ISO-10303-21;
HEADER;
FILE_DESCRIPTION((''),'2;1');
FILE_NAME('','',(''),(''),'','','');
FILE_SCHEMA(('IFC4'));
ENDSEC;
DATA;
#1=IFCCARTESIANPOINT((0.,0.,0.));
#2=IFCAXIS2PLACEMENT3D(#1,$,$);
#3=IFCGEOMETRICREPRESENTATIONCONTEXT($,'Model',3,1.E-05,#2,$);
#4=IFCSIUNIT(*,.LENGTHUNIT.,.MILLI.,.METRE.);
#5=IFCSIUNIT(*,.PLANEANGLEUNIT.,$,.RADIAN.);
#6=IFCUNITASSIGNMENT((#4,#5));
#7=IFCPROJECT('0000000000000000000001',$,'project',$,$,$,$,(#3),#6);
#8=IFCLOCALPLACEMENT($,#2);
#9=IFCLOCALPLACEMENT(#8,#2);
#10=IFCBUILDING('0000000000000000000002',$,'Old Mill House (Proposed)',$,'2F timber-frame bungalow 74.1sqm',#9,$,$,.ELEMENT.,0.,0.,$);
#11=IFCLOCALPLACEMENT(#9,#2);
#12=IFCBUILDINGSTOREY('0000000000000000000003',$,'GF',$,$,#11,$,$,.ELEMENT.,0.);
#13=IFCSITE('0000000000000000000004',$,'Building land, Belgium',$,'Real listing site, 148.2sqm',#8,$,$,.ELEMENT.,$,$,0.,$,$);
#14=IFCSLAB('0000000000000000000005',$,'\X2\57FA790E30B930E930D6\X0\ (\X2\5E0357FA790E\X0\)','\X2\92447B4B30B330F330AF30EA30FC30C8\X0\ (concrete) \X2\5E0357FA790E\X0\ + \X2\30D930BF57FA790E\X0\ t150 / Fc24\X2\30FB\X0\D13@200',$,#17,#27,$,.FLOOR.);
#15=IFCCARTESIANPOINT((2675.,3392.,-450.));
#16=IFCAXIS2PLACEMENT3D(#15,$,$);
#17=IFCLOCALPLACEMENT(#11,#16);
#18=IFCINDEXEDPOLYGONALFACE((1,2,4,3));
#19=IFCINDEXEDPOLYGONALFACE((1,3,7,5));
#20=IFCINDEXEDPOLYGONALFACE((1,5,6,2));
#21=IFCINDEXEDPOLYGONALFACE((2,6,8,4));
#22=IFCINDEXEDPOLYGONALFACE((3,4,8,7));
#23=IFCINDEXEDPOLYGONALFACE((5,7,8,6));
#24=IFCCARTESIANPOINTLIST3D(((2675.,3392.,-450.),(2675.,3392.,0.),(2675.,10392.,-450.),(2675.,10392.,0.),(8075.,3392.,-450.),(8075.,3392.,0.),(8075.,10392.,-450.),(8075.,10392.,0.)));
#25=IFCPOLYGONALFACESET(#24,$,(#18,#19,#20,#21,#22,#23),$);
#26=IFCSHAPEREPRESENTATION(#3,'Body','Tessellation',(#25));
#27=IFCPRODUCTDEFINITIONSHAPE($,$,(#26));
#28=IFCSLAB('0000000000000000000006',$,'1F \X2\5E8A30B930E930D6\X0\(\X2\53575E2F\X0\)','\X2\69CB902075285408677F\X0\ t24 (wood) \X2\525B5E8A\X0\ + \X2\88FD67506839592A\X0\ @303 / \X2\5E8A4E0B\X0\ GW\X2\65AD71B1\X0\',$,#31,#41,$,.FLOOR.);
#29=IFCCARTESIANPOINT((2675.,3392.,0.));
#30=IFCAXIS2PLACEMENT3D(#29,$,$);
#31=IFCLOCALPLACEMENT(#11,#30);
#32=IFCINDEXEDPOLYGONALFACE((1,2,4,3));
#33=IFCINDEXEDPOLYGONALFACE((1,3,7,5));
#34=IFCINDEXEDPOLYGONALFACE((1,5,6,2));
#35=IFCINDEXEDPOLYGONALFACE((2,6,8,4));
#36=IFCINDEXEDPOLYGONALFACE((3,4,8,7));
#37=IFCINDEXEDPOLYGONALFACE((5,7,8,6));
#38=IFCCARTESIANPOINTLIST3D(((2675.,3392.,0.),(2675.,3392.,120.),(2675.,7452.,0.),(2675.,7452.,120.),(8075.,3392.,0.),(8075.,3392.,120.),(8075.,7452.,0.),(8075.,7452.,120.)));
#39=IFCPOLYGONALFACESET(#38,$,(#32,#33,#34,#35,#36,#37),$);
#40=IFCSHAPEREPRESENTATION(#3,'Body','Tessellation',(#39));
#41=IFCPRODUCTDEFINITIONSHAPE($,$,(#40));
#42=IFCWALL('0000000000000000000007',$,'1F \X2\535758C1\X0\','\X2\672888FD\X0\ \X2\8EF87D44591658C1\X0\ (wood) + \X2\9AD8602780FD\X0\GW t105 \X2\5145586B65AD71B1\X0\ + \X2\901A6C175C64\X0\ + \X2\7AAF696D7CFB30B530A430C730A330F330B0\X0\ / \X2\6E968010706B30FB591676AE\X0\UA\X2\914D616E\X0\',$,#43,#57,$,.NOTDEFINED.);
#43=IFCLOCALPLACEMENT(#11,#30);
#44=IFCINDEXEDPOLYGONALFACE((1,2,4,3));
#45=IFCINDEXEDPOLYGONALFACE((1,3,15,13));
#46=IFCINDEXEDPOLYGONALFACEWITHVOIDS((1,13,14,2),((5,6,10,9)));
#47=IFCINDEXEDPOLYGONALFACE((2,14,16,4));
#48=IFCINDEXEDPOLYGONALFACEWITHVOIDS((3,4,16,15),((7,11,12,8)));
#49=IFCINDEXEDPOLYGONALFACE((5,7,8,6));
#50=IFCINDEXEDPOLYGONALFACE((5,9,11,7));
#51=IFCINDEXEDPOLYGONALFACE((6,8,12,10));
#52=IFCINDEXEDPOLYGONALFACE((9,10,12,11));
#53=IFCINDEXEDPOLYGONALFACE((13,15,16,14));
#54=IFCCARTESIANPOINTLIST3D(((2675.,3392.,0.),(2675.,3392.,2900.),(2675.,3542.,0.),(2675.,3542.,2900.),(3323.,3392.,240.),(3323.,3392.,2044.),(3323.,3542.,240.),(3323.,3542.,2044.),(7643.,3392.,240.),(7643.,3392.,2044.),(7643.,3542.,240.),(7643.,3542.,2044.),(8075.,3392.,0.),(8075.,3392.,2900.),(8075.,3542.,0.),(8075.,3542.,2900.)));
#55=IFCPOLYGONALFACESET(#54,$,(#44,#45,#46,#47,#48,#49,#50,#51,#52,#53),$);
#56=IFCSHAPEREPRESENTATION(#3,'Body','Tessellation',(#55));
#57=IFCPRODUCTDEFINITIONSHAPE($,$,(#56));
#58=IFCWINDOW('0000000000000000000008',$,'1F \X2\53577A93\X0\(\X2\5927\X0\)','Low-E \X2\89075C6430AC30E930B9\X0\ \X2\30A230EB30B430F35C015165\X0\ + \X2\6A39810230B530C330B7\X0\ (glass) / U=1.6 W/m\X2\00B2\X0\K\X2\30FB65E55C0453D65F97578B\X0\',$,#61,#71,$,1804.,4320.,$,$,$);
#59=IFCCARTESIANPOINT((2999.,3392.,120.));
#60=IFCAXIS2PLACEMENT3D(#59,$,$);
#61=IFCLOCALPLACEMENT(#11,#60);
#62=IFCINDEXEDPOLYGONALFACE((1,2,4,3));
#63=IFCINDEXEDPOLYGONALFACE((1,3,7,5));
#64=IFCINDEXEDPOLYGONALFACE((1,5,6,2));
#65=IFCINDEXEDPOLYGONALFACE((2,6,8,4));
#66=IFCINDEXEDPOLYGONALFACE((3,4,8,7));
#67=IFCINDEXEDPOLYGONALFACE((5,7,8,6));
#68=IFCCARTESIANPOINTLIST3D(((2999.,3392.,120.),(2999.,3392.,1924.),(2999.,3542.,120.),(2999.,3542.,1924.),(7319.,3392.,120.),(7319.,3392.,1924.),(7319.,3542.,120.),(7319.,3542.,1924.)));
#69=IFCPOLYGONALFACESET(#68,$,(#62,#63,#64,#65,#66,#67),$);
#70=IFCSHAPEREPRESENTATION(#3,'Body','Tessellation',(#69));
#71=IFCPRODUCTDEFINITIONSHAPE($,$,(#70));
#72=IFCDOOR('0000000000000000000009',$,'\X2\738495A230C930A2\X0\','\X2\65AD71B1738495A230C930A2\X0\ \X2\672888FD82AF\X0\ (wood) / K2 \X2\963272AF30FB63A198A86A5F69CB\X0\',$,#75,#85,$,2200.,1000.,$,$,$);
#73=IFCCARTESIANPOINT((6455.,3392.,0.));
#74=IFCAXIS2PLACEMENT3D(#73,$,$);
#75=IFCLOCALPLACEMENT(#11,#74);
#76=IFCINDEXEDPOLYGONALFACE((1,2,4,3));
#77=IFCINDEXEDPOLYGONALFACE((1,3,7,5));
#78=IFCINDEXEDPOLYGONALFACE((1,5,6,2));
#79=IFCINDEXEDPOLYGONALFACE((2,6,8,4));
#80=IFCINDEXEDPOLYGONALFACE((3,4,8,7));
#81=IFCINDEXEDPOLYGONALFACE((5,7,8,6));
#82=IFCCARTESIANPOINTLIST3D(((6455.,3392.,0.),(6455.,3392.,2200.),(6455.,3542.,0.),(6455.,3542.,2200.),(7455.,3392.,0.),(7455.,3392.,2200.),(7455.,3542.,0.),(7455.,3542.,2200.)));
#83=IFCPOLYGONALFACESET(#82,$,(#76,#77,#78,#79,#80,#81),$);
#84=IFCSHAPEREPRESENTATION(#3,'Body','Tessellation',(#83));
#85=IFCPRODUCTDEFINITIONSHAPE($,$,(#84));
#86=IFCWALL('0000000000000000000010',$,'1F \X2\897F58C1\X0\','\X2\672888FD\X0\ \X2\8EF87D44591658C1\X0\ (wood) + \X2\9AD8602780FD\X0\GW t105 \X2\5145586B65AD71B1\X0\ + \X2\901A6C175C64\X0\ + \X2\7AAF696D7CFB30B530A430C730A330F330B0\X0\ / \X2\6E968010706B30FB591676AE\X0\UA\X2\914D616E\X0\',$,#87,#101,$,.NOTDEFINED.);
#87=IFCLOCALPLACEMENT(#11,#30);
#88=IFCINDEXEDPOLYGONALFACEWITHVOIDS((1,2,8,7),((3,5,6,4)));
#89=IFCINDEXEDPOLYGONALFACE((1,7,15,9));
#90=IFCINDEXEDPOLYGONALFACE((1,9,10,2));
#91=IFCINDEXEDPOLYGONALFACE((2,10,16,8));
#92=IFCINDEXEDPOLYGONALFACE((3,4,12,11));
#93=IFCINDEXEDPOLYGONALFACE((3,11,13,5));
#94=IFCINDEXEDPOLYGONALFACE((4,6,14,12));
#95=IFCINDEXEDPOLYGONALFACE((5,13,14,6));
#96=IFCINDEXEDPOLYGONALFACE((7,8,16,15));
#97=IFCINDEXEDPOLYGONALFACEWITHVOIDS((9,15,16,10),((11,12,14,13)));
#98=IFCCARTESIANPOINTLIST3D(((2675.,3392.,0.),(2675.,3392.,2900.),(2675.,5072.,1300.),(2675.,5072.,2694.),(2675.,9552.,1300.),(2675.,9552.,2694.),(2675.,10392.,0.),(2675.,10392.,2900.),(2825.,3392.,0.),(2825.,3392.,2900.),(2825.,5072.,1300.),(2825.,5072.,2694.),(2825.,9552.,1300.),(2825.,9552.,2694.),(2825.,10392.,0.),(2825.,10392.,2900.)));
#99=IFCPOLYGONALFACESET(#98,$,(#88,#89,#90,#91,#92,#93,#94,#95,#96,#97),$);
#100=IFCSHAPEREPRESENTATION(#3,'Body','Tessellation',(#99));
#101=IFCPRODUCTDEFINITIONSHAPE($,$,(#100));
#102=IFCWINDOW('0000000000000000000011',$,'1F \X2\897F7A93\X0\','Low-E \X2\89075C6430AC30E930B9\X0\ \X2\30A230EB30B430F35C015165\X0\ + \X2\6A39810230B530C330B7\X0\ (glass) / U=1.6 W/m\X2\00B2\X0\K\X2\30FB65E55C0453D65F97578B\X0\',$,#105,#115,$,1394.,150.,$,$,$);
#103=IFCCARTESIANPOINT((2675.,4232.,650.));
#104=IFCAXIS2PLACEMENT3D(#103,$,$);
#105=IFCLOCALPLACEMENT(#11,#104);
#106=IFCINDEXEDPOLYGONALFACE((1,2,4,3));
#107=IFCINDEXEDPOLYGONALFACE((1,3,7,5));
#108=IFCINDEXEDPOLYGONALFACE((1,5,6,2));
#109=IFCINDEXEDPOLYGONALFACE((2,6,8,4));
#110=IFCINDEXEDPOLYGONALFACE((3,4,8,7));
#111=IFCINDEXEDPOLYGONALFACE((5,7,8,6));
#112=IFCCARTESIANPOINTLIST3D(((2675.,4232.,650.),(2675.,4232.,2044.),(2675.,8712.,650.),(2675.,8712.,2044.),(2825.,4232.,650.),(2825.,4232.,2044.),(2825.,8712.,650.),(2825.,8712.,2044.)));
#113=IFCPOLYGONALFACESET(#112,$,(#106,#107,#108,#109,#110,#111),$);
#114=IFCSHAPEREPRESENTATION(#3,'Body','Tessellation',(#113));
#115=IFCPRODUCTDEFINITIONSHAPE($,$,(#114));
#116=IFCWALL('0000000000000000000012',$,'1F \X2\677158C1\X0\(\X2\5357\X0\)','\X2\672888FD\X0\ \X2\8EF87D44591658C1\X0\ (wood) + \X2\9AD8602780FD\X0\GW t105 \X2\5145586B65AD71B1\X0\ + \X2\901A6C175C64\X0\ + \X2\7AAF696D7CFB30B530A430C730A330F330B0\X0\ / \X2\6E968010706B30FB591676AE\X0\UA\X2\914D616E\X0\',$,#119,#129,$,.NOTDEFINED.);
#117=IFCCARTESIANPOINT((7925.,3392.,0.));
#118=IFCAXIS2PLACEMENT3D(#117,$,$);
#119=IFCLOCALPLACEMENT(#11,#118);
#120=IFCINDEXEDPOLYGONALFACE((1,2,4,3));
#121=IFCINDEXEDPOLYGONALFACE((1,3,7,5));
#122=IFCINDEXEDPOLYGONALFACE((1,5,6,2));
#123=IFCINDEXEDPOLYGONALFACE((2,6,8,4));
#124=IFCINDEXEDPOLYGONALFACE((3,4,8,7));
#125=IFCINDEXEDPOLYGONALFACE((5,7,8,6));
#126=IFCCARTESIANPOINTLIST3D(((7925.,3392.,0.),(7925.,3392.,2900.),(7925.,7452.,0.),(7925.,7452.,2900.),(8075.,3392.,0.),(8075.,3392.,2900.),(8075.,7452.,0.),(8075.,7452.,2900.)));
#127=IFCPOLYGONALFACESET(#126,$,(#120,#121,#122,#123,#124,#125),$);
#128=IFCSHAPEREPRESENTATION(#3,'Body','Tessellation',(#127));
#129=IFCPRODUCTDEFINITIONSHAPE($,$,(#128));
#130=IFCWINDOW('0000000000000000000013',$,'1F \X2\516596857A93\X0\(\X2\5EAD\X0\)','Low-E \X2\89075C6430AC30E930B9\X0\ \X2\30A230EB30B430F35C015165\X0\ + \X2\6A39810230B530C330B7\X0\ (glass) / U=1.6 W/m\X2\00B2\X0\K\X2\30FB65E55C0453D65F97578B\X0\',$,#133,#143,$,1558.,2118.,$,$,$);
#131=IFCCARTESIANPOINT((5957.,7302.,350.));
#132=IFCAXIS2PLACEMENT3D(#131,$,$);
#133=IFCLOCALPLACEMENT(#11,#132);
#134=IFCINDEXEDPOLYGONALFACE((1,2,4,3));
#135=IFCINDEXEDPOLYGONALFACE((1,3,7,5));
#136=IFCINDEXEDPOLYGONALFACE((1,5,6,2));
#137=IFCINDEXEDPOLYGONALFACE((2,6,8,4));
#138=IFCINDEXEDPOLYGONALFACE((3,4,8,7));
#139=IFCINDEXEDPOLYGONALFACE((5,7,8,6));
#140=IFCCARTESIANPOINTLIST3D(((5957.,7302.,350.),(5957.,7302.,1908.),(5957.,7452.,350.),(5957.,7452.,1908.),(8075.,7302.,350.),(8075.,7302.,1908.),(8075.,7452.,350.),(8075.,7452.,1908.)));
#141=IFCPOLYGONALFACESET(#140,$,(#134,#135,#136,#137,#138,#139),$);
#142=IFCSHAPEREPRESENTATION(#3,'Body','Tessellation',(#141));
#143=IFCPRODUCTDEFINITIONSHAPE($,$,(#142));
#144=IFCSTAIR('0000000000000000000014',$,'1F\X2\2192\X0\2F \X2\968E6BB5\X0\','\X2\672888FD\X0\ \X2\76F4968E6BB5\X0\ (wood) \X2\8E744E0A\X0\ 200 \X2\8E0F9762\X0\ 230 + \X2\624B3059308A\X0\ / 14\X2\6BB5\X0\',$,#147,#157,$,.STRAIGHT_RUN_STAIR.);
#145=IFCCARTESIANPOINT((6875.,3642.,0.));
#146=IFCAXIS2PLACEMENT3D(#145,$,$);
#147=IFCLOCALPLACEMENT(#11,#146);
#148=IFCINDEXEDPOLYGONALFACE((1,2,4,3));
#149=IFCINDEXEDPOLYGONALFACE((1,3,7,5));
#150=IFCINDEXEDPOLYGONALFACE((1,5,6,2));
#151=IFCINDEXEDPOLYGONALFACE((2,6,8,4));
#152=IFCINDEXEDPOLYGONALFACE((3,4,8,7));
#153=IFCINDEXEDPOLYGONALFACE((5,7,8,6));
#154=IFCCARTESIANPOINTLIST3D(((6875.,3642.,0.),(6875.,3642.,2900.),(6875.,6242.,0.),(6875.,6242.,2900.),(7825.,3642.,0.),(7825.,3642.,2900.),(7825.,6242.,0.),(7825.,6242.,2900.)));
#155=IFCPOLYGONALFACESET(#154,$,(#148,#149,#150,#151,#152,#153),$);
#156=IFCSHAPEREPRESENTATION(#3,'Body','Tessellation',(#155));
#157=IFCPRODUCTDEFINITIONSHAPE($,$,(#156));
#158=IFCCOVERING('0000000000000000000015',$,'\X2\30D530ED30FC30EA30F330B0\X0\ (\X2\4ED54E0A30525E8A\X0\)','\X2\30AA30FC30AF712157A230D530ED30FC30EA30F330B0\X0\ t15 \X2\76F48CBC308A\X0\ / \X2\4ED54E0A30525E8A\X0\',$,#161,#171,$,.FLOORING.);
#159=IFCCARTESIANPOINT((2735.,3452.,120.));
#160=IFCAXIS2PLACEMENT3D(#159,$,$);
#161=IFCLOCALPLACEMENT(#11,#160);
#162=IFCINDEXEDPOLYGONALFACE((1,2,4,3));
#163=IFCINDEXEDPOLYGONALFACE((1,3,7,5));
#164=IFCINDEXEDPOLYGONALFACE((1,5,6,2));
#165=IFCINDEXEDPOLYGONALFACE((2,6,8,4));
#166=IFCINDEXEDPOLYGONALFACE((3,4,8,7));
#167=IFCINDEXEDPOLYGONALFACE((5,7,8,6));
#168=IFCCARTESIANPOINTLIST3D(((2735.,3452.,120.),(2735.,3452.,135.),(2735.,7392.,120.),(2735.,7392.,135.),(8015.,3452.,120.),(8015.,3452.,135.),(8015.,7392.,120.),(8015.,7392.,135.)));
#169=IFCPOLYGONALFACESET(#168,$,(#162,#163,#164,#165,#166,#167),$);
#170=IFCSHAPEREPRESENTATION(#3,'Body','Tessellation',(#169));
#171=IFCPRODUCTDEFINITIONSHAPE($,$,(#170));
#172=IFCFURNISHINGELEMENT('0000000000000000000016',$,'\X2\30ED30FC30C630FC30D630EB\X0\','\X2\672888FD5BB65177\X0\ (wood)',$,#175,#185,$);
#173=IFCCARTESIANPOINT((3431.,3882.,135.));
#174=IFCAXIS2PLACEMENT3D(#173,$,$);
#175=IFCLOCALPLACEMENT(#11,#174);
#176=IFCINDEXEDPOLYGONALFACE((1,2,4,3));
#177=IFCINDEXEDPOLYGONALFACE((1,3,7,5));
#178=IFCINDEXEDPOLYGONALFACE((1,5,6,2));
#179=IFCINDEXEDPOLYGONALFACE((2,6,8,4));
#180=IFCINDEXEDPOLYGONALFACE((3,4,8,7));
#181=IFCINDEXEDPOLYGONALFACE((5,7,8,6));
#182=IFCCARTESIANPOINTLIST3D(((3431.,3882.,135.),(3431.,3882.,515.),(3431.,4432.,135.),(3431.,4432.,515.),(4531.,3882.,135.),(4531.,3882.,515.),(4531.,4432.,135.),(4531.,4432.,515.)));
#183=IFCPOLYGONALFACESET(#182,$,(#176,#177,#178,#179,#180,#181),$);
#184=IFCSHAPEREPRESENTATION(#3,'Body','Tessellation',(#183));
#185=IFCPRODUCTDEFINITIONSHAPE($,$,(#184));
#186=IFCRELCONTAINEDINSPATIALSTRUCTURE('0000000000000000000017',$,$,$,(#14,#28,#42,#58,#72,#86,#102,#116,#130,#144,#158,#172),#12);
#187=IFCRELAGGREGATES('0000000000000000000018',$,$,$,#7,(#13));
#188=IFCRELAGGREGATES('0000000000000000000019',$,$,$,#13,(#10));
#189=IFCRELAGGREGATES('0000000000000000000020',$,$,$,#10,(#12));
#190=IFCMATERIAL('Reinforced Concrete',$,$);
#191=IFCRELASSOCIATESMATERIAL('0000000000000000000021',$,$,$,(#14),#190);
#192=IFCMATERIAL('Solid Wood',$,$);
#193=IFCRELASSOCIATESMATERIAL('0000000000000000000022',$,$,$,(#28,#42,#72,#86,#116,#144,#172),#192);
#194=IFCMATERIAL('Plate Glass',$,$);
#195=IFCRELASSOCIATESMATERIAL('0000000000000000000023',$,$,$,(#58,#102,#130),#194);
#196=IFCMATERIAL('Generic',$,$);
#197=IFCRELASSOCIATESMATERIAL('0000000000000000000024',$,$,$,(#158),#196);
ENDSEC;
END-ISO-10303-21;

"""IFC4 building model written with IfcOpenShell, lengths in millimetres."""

from ifc_helpers import new_model, si_unit, frame, frame_2d, origin, place, context, project, spatial, rectangle, extrude, material, element, fill, save


model = new_model("IFC4")

# Units and contexts
model_context = context("Model", 3, precision=1e-05, world=origin())
ifc_project = project(units=[si_unit("LENGTHUNIT", "METRE", prefix="MILLI"), si_unit("PLANEANGLEUNIT", "RADIAN")], contexts=[model_context])

# Site, building, storey
site_placement = place(None, origin())
site = spatial("IfcSite", under=ifc_project, at=site_placement, Name="Building land, Belgium", ObjectType="Real listing site, 148.2sqm", CompositionType="ELEMENT", RefElevation=0.0)
building_placement = place(site_placement, origin())
building = spatial("IfcBuilding", under=site, at=building_placement, Name="Old Mill House (Proposed)", ObjectType="2F timber-frame bungalow 74.1sqm", CompositionType="ELEMENT", ElevationOfRefHeight=0.0, ElevationOfTerrain=0.0)
storey_placement = place(building_placement, origin())
storey = spatial("IfcBuildingStorey", under=building, at=storey_placement, Name="GF", CompositionType="ELEMENT", Elevation=0.0)

# Slabs
ifc_material_1 = material(Name="Reinforced Concrete")
slab_1_placement = place(storey_placement, frame((2675.0, 3392.0, -450.0)))
element("IfcSlab", 1, at=slab_1_placement, inside=storey, material=ifc_material_1, Name="基礎スラブ (布基礎)", Description="鉄筋コンクリート (concrete) 布基礎 + ベタ基礎 t150 / Fc24・D13@200", PredefinedType="FLOOR", context=model_context, shape_type="SweptSolid", body=[
    extrude(rectangle(XDim=5400.0, YDim=7000.0, at=frame_2d((2700.0, 3500.0))), frame((2675.0, 3392.0, -450.0)), (0.0, 0.0, 1.0), 450.0),
])
ifc_material_2 = material(Name="Solid Wood")
slab_2_placement = place(storey_placement, frame((2675.0, 3392.0, 0.0)))
element("IfcSlab", 2, at=slab_2_placement, inside=storey, material=ifc_material_2, Name="1F 床スラブ(南帯)", Description="構造用合板 t24 (wood) 剛床 + 製材根太 @303 / 床下 GW断熱", PredefinedType="FLOOR", context=model_context, shape_type="SweptSolid", body=[
    extrude(rectangle(XDim=5400.0, YDim=4060.0, at=frame_2d((2700.0, 2030.0))), frame((2675.0, 3392.0, 0.0)), (0.0, 0.0, 1.0), 120.0),
])

# Wall, openings, window, door
wall_1_placement = place(storey_placement, frame((2675.0, 3392.0, 0.0)))
wall_1 = element("IfcWall", 3, at=wall_1_placement, inside=storey, material=ifc_material_2, Name="1F 南壁", Description="木製 軸組外壁 (wood) + 高性能GW t105 充填断熱 + 通気層 + 窯業系サイディング / 準耐火・外皮UA配慮", PredefinedType="NOTDEFINED", context=model_context, shape_type="SweptSolid", body=[
    extrude(rectangle(XDim=5400.0, YDim=150.0, at=frame_2d((2700.0, 75.0))), frame((2675.0, 3392.0, 0.0)), (0.0, 0.0, 1.0), 2900.0),
])
opening_1_placement = place(storey_placement, frame((2999.0, 3392.0, 120.0)))
opening_1 = element("IfcOpeningElement", 4, at=opening_1_placement, cuts=wall_1, PredefinedType="NOTDEFINED", context=model_context, shape_type="SweptSolid", body=[
    extrude(rectangle(XDim=4320.0, YDim=150.0, at=frame_2d((2160.0, 75.0))), frame((2999.0, 3392.0, 120.0)), (0.0, 0.0, 1.0), 1804.0),
])
opening_2_placement = place(storey_placement, frame((6455.0, 3392.0, 0.0)))
opening_2 = element("IfcOpeningElement", 5, at=opening_2_placement, cuts=wall_1, PredefinedType="NOTDEFINED", context=model_context, shape_type="SweptSolid", body=[
    extrude(rectangle(XDim=1000.0, YDim=150.0, at=frame_2d((500.0, 75.0))), frame((6455.0, 3392.0, 0.0)), (0.0, 0.0, 1.0), 2200.0),
])
ifc_material_3 = material(Name="Plate Glass")
window_1_placement = place(storey_placement, frame((2999.0, 3392.0, 120.0)))
window_1 = element("IfcWindow", 6, at=window_1_placement, inside=storey, material=ifc_material_3, Name="1F 南窓(大)", Description="Low-E 複層ガラス アルゴン封入 + 樹脂サッシ (glass) / U=1.6 W/m²K・日射取得型", OverallHeight=1804.0, OverallWidth=4320.0, context=model_context, shape_type="SweptSolid", body=[
    extrude(rectangle(XDim=4320.0, YDim=150.0, at=frame_2d((2160.0, 75.0))), frame((2999.0, 3392.0, 120.0)), (0.0, 0.0, 1.0), 1804.0),
])
fill(opening_1, window_1)
door_1_placement = place(storey_placement, frame((6455.0, 3392.0, 0.0)))
door_1 = element("IfcDoor", 7, at=door_1_placement, inside=storey, material=ifc_material_2, Name="玄関ドア", Description="断熱玄関ドア 木製芯 (wood) / K2 防犯・採風機構", OverallHeight=2200.0, OverallWidth=1000.0, context=model_context, shape_type="SweptSolid", body=[
    extrude(rectangle(XDim=1000.0, YDim=150.0, at=frame_2d((500.0, 75.0))), frame((6455.0, 3392.0, 0.0)), (0.0, 0.0, 1.0), 2200.0),
])
fill(opening_2, door_1)

# Walls, openings, windows
wall_2_placement = place(storey_placement, frame((2675.0, 3392.0, 0.0)))
wall_2 = element("IfcWall", 8, at=wall_2_placement, inside=storey, material=ifc_material_2, Name="1F 西壁", Description="木製 軸組外壁 (wood) + 高性能GW t105 充填断熱 + 通気層 + 窯業系サイディング / 準耐火・外皮UA配慮", PredefinedType="NOTDEFINED", context=model_context, shape_type="SweptSolid", body=[
    extrude(rectangle(XDim=150.0, YDim=7000.0, at=frame_2d((75.0, 3500.0))), frame((2675.0, 3392.0, 0.0)), (0.0, 0.0, 1.0), 2900.0),
])
opening_3_placement = place(storey_placement, frame((2675.0, 4232.0, 650.0)))
opening_3 = element("IfcOpeningElement", 9, at=opening_3_placement, cuts=wall_2, PredefinedType="NOTDEFINED", context=model_context, shape_type="SweptSolid", body=[
    extrude(rectangle(XDim=150.0, YDim=4480.0, at=frame_2d((75.0, 2240.0))), frame((2675.0, 4232.0, 650.0)), (0.0, 0.0, 1.0), 1394.0),
])
window_2_placement = place(storey_placement, frame((2675.0, 4232.0, 650.0)))
window_2 = element("IfcWindow", 10, at=window_2_placement, inside=storey, material=ifc_material_3, Name="1F 西窓", Description="Low-E 複層ガラス アルゴン封入 + 樹脂サッシ (glass) / U=1.6 W/m²K・日射取得型", OverallHeight=1394.0, OverallWidth=150.0, context=model_context, shape_type="SweptSolid", body=[
    extrude(rectangle(XDim=150.0, YDim=4480.0, at=frame_2d((75.0, 2240.0))), frame((2675.0, 4232.0, 650.0)), (0.0, 0.0, 1.0), 1394.0),
])
fill(opening_3, window_2)
wall_3_placement = place(storey_placement, frame((7925.0, 3392.0, 0.0)))
wall_3 = element("IfcWall", 11, at=wall_3_placement, inside=storey, material=ifc_material_2, Name="1F 東壁(南)", Description="木製 軸組外壁 (wood) + 高性能GW t105 充填断熱 + 通気層 + 窯業系サイディング / 準耐火・外皮UA配慮", PredefinedType="NOTDEFINED", context=model_context, shape_type="SweptSolid", body=[
    extrude(rectangle(XDim=150.0, YDim=4060.0, at=frame_2d((75.0, 2030.0))), frame((7925.0, 3392.0, 0.0)), (0.0, 0.0, 1.0), 2900.0),
])
opening_4_placement = place(storey_placement, frame((5957.0, 7302.0, 350.0)))
opening_4 = element("IfcOpeningElement", 12, at=opening_4_placement, cuts=wall_3, PredefinedType="NOTDEFINED", context=model_context, shape_type="SweptSolid", body=[
    extrude(rectangle(XDim=2118.0, YDim=150.0, at=frame_2d((1059.0, 75.0))), frame((5957.0, 7302.0, 350.0)), (0.0, 0.0, 1.0), 1558.0),
])
window_3_placement = place(storey_placement, frame((5957.0, 7302.0, 350.0)))
window_3 = element("IfcWindow", 13, at=window_3_placement, inside=storey, material=ifc_material_3, Name="1F 入隅窓(庭)", Description="Low-E 複層ガラス アルゴン封入 + 樹脂サッシ (glass) / U=1.6 W/m²K・日射取得型", OverallHeight=1558.0, OverallWidth=2118.0, context=model_context, shape_type="SweptSolid", body=[
    extrude(rectangle(XDim=2118.0, YDim=150.0, at=frame_2d((1059.0, 75.0))), frame((5957.0, 7302.0, 350.0)), (0.0, 0.0, 1.0), 1558.0),
])
fill(opening_4, window_3)

# Stair
stair_placement = place(storey_placement, frame((6875.0, 3642.0, 0.0)))
element("IfcStair", 14, at=stair_placement, inside=storey, material=ifc_material_2, Name="1F→2F 階段", Description="木製 直階段 (wood) 蹴上 200 踏面 230 + 手すり / 14段", PredefinedType="STRAIGHT_RUN_STAIR", context=model_context, shape_type="SweptSolid", body=[
    extrude(rectangle(XDim=950.0, YDim=2600.0, at=frame_2d((475.0, 1300.0))), frame((6875.0, 3642.0, 0.0)), (0.0, 0.0, 1.0), 2900.0),
])

# Covering
ifc_material_4 = material(Name="Generic")
covering_placement = place(storey_placement, frame((2735.0, 3452.0, 120.0)))
element("IfcCovering", 15, at=covering_placement, inside=storey, material=ifc_material_4, Name="フローリング (仕上げ床)", Description="オーク無垢フローリング t15 直貼り / 仕上げ床", PredefinedType="FLOORING", context=model_context, shape_type="SweptSolid", body=[
    extrude(rectangle(XDim=5280.0, YDim=3940.0, at=frame_2d((2640.0, 1970.0))), frame((2735.0, 3452.0, 120.0)), (0.0, 0.0, 1.0), 15.0),
])

# Furnishing element
furnishing_1_placement = place(storey_placement, frame((3431.0, 3882.0, 135.0)))
element("IfcFurnishingElement", 16, at=furnishing_1_placement, inside=storey, material=ifc_material_2, Name="ローテーブル", Description="木製家具 (wood)", context=model_context, shape_type="SweptSolid", body=[
    extrude(rectangle(XDim=1100.0, YDim=550.0, at=frame_2d((550.0, 275.0))), frame((3431.0, 3882.0, 135.0)), (0.0, 0.0, 1.0), 380.0),
])

save(model, "model.ifc")
